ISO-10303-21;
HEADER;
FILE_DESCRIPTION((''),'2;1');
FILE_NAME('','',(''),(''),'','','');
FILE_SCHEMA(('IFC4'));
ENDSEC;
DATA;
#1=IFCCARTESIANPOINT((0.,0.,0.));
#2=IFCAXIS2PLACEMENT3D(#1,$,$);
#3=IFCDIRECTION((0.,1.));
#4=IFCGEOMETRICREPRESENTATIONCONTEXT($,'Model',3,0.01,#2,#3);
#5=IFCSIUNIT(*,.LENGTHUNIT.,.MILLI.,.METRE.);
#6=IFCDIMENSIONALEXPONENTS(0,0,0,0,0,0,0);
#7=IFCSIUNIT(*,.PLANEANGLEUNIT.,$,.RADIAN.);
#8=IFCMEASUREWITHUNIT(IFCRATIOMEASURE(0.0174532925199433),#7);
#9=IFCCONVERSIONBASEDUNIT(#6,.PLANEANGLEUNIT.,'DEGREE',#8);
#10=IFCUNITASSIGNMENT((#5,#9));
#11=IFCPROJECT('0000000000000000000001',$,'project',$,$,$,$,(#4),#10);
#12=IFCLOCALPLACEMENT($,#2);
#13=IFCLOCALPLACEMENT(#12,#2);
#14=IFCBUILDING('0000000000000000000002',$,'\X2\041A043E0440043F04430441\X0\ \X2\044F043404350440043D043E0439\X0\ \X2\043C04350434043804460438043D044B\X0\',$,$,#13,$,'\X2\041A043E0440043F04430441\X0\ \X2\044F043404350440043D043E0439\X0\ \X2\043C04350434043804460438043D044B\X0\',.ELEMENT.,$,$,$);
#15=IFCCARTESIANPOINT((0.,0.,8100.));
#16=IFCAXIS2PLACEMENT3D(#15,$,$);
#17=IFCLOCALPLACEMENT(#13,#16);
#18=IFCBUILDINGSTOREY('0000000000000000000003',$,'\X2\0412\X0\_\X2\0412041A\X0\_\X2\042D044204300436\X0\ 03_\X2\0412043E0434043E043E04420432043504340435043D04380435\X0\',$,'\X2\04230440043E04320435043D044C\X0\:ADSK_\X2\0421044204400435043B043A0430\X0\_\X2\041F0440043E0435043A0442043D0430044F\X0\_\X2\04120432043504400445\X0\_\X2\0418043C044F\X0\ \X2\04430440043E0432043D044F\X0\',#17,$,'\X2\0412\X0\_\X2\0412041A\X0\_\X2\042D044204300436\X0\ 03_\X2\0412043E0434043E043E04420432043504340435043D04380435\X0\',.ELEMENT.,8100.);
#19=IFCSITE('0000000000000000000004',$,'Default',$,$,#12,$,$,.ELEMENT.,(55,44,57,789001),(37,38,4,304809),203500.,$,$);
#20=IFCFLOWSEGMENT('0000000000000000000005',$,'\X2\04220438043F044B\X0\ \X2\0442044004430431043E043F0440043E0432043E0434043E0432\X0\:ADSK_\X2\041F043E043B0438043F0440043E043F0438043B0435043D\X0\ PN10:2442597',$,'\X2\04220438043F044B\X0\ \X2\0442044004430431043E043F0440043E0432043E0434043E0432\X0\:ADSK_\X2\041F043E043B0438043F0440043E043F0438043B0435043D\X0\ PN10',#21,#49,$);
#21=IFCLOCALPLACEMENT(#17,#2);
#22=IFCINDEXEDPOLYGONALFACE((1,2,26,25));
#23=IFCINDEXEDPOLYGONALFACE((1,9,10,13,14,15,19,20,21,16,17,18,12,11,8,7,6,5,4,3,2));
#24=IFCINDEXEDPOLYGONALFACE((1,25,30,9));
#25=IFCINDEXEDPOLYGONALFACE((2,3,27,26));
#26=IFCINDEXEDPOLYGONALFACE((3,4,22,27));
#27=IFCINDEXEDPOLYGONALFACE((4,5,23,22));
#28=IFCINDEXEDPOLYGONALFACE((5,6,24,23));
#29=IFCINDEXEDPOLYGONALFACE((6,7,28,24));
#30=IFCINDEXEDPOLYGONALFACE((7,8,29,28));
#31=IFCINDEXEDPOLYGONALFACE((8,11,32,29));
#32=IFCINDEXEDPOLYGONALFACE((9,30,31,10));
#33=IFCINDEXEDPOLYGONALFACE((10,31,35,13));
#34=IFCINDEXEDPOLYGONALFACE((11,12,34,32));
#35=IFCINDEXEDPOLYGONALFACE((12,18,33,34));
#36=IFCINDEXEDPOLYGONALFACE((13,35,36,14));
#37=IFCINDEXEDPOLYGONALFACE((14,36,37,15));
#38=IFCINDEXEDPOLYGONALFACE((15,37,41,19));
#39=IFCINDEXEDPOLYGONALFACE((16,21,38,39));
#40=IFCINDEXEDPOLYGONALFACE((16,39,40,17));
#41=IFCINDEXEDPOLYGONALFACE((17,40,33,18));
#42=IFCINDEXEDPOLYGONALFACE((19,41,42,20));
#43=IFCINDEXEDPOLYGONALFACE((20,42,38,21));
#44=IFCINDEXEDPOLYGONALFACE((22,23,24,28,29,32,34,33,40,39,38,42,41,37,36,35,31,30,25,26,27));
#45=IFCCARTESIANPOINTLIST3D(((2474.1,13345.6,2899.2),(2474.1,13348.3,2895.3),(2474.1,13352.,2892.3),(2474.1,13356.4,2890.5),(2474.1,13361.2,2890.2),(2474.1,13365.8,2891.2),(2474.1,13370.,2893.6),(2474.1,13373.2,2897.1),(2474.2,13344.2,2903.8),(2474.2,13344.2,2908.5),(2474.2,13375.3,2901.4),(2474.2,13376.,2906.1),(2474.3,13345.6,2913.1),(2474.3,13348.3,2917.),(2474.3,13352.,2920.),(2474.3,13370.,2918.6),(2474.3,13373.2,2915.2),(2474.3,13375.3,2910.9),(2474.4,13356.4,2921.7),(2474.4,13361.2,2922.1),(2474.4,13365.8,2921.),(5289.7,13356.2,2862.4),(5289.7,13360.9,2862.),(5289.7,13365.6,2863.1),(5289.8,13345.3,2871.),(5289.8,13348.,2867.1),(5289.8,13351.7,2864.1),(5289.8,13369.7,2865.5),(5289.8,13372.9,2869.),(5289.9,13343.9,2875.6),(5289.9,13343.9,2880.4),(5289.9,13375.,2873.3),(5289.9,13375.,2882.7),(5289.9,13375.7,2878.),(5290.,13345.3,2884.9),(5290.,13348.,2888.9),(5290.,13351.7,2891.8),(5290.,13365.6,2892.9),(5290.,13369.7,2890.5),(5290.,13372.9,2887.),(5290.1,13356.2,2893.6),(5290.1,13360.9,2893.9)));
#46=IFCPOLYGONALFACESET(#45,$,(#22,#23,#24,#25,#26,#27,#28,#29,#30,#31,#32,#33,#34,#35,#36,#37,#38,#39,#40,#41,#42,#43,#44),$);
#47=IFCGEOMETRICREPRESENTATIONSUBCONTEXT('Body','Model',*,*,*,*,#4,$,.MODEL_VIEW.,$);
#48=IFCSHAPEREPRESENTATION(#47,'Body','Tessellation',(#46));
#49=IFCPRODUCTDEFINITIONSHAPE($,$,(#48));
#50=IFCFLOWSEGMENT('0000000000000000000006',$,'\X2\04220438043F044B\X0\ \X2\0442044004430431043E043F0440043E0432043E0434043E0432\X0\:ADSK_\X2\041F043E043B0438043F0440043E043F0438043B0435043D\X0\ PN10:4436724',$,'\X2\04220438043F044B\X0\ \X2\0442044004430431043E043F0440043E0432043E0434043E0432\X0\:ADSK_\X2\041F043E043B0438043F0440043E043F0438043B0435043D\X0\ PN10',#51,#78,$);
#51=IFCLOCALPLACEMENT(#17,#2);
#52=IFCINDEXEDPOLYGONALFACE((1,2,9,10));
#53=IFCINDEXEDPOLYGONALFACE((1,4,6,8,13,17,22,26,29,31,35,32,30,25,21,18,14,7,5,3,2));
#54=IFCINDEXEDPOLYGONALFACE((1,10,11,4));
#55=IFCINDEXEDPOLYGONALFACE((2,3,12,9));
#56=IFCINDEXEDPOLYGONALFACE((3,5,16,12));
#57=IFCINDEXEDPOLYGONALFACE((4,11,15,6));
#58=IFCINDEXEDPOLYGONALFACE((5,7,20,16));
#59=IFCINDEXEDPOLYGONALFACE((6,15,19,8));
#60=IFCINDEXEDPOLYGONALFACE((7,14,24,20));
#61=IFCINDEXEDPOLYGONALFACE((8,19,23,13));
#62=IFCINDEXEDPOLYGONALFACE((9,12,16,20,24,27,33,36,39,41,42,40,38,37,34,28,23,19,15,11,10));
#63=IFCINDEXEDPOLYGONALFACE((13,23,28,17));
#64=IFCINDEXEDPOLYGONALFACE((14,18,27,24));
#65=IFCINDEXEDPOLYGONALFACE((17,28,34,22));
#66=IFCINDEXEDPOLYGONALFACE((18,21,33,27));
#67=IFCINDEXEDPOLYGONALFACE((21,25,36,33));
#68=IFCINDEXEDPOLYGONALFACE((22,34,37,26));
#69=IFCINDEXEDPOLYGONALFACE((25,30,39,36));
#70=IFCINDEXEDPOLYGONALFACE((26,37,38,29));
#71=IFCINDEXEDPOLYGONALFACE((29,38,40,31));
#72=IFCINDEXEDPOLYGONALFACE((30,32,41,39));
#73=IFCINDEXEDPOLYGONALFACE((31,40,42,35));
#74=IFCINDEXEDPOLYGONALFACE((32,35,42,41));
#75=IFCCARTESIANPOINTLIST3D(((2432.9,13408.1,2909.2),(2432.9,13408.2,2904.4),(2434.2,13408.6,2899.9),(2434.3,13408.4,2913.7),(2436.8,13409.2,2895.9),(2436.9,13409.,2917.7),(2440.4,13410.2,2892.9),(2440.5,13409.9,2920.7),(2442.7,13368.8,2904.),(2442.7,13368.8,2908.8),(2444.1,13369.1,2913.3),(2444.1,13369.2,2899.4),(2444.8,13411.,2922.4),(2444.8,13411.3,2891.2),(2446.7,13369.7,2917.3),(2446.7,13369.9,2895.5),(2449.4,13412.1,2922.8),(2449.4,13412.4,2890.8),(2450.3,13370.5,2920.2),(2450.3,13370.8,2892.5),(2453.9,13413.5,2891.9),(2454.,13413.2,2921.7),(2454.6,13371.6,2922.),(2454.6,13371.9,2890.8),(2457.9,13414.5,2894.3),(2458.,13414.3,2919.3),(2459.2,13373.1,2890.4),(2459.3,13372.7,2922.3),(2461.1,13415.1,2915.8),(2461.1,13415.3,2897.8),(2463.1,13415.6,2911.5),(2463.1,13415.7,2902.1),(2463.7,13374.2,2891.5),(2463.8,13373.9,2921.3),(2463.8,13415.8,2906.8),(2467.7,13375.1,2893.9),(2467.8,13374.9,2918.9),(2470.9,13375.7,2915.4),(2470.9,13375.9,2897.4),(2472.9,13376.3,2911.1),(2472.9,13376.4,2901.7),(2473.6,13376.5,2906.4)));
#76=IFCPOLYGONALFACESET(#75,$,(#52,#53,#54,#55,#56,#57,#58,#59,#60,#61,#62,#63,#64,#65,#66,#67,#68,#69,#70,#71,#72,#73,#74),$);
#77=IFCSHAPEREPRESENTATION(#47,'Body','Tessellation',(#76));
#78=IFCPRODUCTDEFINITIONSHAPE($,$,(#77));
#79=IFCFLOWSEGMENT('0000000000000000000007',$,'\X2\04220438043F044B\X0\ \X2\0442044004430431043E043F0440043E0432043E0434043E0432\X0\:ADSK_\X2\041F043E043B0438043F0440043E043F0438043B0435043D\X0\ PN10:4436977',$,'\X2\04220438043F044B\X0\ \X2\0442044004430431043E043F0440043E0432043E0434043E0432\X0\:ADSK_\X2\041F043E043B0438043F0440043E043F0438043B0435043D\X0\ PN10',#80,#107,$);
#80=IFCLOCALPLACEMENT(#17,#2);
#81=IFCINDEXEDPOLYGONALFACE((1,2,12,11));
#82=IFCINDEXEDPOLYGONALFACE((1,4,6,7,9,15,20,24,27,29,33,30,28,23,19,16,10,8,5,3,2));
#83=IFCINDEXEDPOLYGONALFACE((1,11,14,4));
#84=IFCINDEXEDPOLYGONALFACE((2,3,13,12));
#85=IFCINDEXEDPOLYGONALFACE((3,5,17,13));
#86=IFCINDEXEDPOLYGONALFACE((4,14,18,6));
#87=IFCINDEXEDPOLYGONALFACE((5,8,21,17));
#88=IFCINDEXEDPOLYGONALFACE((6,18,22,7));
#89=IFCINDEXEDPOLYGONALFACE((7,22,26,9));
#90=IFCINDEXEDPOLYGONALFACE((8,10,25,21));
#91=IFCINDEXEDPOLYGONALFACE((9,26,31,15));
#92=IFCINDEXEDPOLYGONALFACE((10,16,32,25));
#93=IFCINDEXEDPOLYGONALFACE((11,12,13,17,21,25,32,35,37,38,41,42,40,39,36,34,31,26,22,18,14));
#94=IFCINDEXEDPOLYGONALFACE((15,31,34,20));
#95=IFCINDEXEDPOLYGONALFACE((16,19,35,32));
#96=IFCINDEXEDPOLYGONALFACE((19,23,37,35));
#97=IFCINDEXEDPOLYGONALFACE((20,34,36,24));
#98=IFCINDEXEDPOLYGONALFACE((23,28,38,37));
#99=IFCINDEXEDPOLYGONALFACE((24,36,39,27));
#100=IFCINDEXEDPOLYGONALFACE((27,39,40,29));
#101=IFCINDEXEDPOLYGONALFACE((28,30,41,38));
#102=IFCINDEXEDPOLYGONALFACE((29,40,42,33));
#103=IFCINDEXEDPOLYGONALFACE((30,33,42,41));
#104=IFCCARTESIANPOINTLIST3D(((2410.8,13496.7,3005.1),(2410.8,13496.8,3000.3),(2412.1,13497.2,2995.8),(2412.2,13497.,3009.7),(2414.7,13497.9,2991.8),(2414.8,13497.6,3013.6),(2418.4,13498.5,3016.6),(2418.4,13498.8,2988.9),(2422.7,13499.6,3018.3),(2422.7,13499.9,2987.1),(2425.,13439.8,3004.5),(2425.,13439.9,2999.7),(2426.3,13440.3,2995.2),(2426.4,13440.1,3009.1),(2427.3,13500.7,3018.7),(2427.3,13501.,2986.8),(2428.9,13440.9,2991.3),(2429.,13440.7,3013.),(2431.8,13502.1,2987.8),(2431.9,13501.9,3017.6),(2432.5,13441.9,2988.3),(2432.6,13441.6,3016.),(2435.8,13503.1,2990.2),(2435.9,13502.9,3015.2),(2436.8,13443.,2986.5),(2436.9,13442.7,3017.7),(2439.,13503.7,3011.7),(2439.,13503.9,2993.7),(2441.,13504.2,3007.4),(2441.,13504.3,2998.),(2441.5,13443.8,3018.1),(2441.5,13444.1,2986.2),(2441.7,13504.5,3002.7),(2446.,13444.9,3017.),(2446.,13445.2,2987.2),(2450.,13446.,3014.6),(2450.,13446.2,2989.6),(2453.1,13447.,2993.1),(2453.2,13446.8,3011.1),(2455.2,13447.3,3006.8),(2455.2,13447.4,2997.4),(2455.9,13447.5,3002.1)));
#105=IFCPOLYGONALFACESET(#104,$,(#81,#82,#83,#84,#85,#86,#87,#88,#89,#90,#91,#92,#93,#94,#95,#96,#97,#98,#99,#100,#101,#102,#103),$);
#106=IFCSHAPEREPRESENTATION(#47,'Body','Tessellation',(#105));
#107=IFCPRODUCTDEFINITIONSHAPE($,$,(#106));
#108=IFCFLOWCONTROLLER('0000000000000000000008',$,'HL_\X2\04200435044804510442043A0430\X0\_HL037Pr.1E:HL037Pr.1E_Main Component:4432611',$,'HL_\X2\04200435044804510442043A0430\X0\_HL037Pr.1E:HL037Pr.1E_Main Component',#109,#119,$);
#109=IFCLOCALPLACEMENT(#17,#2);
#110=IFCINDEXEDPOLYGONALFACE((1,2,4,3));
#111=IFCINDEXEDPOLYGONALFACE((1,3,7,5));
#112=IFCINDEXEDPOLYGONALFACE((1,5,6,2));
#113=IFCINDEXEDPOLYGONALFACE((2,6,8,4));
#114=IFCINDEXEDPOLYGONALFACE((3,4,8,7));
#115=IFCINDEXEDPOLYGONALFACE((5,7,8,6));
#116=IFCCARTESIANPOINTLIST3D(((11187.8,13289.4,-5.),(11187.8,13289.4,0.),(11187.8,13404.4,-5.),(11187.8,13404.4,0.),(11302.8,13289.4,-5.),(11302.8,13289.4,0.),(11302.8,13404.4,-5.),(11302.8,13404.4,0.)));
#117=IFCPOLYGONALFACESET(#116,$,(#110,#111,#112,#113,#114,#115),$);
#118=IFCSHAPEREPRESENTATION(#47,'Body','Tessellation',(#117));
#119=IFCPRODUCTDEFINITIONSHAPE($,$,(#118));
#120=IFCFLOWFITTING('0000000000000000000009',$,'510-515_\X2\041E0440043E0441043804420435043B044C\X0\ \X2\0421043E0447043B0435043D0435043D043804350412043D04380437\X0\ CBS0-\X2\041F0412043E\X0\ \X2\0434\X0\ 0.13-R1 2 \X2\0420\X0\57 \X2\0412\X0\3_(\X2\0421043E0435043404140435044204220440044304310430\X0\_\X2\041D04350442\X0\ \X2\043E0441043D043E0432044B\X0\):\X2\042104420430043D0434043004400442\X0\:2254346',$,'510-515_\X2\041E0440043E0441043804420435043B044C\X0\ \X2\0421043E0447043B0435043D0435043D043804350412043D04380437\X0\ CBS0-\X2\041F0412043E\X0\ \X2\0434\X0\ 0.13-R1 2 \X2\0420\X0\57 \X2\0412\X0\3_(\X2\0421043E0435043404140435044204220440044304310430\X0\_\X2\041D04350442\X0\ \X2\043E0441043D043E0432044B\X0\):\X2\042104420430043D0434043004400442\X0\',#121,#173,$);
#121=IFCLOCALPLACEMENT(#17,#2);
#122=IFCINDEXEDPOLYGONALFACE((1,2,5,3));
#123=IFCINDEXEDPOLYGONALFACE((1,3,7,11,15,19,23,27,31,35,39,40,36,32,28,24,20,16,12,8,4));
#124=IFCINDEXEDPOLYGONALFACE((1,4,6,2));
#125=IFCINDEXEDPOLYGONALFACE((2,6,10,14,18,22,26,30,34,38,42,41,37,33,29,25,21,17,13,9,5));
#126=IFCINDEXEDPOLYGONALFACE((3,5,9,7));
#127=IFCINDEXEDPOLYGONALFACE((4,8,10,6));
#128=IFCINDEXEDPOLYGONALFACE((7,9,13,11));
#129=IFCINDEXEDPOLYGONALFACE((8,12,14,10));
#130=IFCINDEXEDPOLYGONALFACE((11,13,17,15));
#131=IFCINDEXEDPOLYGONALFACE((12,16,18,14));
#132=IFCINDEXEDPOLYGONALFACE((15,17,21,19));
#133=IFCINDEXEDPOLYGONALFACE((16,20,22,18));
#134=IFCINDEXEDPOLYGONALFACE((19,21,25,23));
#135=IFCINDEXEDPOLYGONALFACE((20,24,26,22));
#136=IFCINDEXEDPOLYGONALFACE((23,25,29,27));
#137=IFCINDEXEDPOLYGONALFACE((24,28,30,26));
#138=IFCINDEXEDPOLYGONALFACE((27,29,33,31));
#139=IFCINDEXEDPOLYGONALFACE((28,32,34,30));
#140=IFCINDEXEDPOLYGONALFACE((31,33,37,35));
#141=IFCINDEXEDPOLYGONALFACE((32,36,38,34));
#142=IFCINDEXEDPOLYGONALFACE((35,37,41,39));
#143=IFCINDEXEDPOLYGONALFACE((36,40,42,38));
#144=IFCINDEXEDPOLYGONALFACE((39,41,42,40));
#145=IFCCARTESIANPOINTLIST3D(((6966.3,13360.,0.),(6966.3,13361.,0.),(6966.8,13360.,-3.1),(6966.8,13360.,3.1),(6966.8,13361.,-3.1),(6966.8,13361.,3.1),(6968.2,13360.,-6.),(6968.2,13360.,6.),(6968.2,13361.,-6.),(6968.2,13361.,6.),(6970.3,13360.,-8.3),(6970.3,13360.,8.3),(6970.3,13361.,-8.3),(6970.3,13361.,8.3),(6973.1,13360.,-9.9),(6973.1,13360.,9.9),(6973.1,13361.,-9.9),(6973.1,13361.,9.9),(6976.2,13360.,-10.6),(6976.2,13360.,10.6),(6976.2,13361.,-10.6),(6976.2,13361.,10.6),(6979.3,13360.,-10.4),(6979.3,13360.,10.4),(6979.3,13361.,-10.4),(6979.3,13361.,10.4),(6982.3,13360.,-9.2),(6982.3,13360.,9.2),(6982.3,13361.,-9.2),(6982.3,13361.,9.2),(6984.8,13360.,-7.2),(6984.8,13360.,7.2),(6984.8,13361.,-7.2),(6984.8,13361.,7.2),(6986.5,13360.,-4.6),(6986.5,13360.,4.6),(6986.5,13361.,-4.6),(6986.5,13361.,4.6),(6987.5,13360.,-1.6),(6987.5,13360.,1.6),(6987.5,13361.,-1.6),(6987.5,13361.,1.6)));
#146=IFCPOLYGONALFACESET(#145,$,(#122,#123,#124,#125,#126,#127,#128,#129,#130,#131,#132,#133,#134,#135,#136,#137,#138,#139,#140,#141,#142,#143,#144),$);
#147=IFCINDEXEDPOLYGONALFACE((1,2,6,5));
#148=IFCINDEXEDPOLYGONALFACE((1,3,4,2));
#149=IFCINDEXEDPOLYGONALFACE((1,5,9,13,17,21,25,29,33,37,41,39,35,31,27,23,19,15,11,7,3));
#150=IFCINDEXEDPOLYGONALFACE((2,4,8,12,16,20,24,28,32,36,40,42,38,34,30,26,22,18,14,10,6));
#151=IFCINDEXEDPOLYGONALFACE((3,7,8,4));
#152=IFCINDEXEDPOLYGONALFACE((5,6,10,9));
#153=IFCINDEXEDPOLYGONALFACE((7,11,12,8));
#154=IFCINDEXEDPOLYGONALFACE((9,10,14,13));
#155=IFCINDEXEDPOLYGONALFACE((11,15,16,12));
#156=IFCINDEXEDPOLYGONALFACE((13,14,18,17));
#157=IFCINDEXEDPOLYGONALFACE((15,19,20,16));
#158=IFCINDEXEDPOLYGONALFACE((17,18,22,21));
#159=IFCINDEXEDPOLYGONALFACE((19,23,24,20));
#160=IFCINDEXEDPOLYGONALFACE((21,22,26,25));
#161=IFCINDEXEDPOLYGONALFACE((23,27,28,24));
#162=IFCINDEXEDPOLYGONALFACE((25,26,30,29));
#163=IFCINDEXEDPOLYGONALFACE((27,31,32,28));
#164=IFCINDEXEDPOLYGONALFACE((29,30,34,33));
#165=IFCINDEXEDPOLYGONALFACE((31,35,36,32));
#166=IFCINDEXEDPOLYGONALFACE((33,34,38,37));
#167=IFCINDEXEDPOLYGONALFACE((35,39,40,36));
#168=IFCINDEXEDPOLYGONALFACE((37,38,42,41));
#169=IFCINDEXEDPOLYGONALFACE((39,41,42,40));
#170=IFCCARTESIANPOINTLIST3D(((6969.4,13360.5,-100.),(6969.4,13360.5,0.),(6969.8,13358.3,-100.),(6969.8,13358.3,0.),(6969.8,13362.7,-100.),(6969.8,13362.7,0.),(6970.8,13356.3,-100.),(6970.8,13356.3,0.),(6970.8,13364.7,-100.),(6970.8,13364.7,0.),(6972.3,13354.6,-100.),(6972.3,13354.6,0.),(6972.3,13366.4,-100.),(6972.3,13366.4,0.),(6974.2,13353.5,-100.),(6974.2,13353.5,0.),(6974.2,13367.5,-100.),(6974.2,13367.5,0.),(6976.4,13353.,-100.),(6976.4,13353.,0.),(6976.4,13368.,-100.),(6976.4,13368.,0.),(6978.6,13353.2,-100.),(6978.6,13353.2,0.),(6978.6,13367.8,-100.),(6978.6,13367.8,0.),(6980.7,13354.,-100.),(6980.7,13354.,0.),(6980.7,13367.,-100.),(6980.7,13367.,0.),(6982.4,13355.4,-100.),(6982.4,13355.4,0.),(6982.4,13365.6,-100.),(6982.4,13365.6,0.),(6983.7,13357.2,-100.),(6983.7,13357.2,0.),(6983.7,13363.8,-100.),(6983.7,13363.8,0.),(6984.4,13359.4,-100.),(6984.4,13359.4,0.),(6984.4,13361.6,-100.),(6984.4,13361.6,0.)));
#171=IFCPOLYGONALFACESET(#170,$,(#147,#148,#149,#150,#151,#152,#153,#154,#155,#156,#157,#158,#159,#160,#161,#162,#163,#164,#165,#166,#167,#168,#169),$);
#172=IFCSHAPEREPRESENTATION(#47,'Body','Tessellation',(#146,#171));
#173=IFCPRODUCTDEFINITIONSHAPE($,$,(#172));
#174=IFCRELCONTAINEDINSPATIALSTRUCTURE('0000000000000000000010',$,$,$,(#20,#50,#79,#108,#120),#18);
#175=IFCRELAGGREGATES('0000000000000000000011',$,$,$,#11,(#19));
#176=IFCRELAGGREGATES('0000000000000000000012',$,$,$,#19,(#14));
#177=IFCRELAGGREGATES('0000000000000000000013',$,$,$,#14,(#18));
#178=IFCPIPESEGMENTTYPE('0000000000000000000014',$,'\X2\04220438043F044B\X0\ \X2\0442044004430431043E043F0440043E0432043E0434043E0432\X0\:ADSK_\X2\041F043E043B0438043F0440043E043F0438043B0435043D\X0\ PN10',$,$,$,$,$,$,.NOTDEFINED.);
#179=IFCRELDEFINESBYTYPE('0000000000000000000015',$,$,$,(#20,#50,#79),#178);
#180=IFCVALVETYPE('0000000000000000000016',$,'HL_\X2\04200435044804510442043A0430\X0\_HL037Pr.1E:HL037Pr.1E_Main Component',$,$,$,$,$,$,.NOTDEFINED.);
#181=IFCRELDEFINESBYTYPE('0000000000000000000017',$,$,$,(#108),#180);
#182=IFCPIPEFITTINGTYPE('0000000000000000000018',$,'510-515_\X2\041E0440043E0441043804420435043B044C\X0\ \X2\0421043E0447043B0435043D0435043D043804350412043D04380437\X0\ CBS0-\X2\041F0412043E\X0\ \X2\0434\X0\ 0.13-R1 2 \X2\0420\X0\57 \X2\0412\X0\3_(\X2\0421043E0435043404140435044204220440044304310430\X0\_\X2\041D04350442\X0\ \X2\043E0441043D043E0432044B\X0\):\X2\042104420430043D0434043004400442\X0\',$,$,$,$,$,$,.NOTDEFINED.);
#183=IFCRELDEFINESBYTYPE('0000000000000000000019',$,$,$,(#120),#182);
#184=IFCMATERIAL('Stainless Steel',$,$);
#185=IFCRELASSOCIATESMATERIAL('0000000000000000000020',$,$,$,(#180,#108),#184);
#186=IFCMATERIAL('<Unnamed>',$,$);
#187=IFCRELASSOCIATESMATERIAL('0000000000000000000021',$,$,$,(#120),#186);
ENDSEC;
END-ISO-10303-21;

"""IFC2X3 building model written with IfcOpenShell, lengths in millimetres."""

from ifc_helpers import new_model, entity, si_unit, converted_unit, direction, frame, origin, origin_2d_with_axis, place, context, subcontext, project, spatial, rectangle, circle, extrude, source, transform, mapped, material, type_object, type_shapes, element, save


model = new_model("IFC2X3")

# Units and contexts
model_context = context("Model", 3, precision=0.01, world=origin(), true_north=direction((0.0, 1.0)))
body_context = subcontext(model_context, "Body", "Model", "MODEL_VIEW")
ifc_project = project(units=[si_unit("LENGTHUNIT", "METRE", prefix="MILLI"), converted_unit("PLANEANGLEUNIT", "DEGREE", entity("IfcRatioMeasure", 0.0174532925199433), si_unit("PLANEANGLEUNIT", "RADIAN"), dimensions=[0, 0, 0, 0, 0, 0, 0])], contexts=[model_context])

# Site, building, storey
site_placement = place(None, origin())
site = spatial("IfcSite", under=ifc_project, at=site_placement, Name="Default", CompositionType="ELEMENT", RefLatitude=(55, 44, 57, 789001), RefLongitude=(37, 38, 4, 304809), RefElevation=203500.0)
building_placement = place(site_placement, origin())
building = spatial("IfcBuilding", under=site, at=building_placement, Name="Корпус ядерной медицины", LongName="Корпус ядерной медицины", CompositionType="ELEMENT")
storey_placement = place(building_placement, frame((0.0, 0.0, 8100.0)))
storey = spatial("IfcBuildingStorey", under=building, at=storey_placement, Name="В_ВК_Этаж 03_Водоотведение", ObjectType="Уровень:ADSK_Стрелка_Проектная_Вверх_Имя уровня", LongName="В_ВК_Этаж 03_Водоотведение", CompositionType="ELEMENT", Elevation=8100.0)

# Flow segments
pipe_segment_type_1 = type_object("IfcPipeSegmentType", Name="Типы трубопроводов:ADSK_Полипропилен PN10", PredefinedType="NOTDEFINED")
flow_segment_1_placement = place(storey_placement, frame((2472.4, 13342.1, 2860.4)))
element("IfcFlowSegment", 1, at=flow_segment_1_placement, inside=storey, type_object=pipe_segment_type_1, Name="Типы трубопроводов:ADSK_Полипропилен PN10:2442597", ObjectType="Типы трубопроводов:ADSK_Полипропилен PN10", context=body_context, shape_type="SweptSolid", body=[
    extrude(circle(Radius=16.0, at=origin_2d_with_axis()), frame((1.8, 17.9, 45.8), z_axis=(0.99995, -0.0001, -0.009999), x_axis=(0.0001, 1.0, 0.0)), (0.0, 0.0, 1.0), 2815.8),
])
flow_segment_2_placement = place(storey_placement, frame((2431.1, 13367.1, 2888.8)))
element("IfcFlowSegment", 2, at=flow_segment_2_placement, inside=storey, type_object=pipe_segment_type_1, Name="Типы трубопроводов:ADSK_Полипропилен PN10:4436724", ObjectType="Типы трубопроводов:ADSK_Полипропилен PN10", context=body_context, shape_type="SweptSolid", body=[
    extrude(circle(Radius=16.0, at=origin_2d_with_axis()), frame((26.9, 5.5, 17.6), z_axis=(-0.24191, 0.970247, 0.01), x_axis=(0.970296, 0.241922, 0.0)), (0.0, 0.0, 1.0), 40.6),
])
flow_segment_3_placement = place(storey_placement, frame((2409.0, 13438.2, 2984.5)))
element("IfcFlowSegment", 3, at=flow_segment_3_placement, inside=storey, type_object=pipe_segment_type_1, Name="Типы трубопроводов:ADSK_Полипропилен PN10:4436977", ObjectType="Типы трубопроводов:ADSK_Полипропилен PN10", context=body_context, shape_type="SweptSolid", body=[
    extrude(circle(Radius=16.0, at=origin_2d_with_axis()), frame((17.1, 62.4, 18.2), z_axis=(0.24191, -0.970247, -0.009998), x_axis=(0.970296, 0.241922, 0.0)), (0.0, 0.0, 1.0), 58.7),
])

# Flow controller
ifc_material_1 = material(Name="Stainless Steel")
valve_type = type_object("IfcValveType", Name="HL_Решётка_HL037Pr.1E:HL037Pr.1E_Main Component", PredefinedType="NOTDEFINED", material=ifc_material_1)
shared_shape_1 = source(origin(), body_context, "Body", "SweptSolid", [
    extrude(rectangle(XDim=115.0, YDim=115.0, at=origin_2d_with_axis()), frame((0.0, 0.0, -5.0), z_axis=(0.0, 0.0, 1.0), x_axis=(0.0, -1.0, 0.0)), (0.0, 0.0, 1.0), 5.0),
])
type_shapes(valve_type, [shared_shape_1])
flow_controller_placement = place(storey_placement, frame((11245.3, 13346.9, 0.0), z_axis=(0.0, 0.0, 1.0), x_axis=(0.0, 1.0, 0.0)))
element("IfcFlowController", 4, at=flow_controller_placement, inside=storey, type_object=valve_type, material=ifc_material_1, Name="HL_Решётка_HL037Pr.1E:HL037Pr.1E_Main Component:4432611", ObjectType="HL_Решётка_HL037Pr.1E:HL037Pr.1E_Main Component", context=body_context, shape_type="MappedRepresentation", body=[
    mapped(shared_shape_1, transform((0.0, 0.0, 0.0), scale=1.0)),
])

# Flow fitting
ifc_material_2 = material(Name="<Unnamed>")
pipe_fitting_type_1 = type_object("IfcPipeFittingType", Name="510-515_Ороситель СочленениеВниз CBS0-ПВо д 0.13-R1 2 Р57 В3_(СоедДетТруба_Нет основы):Стандарт", PredefinedType="NOTDEFINED")
shared_shape_2 = source(origin(), body_context, "Body", "SweptSolid", [
    extrude(circle(Radius=10.7, at=origin_2d_with_axis()), frame((-0.5, 0.0, 0.0), z_axis=(1.0, 0.0, 0.0), x_axis=(0.0, 1.0, 0.0)), (0.0, 0.0, 1.0), 1.0),
    extrude(circle(Radius=7.5, at=origin_2d_with_axis()), frame((0.0, 0.0, -100.0), z_axis=(0.0, 0.0, 1.0), x_axis=(0.0, 1.0, 0.0)), (0.0, 0.0, 1.0), 100.0),
])
type_shapes(pipe_fitting_type_1, [shared_shape_2])
for number, where, z_axis, x_axis, name in (
    (5, (6976.9, 13360.5, 0.0), (0.0, 0.0, 1.0), (0.0, 1.0, 0.0), "510-515_Ороситель СочленениеВниз CBS0-ПВо д 0.13-R1 2 Р57 В3_(СоедДетТруба_Нет основы):Стандарт:2254346"),
):
    element("IfcFlowFitting", number, at=place(storey_placement, frame(where, z_axis=z_axis, x_axis=x_axis)), inside=storey, type_object=pipe_fitting_type_1, material=ifc_material_2, Name=name, ObjectType="510-515_Ороситель СочленениеВниз CBS0-ПВо д 0.13-R1 2 Р57 В3_(СоедДетТруба_Нет основы):Стандарт", context=body_context, shape_type="MappedRepresentation", body=[
        mapped(shared_shape_2, transform((0.0, 0.0, 0.0), scale=1.0)),
    ])

save(model, "model.ifc")
